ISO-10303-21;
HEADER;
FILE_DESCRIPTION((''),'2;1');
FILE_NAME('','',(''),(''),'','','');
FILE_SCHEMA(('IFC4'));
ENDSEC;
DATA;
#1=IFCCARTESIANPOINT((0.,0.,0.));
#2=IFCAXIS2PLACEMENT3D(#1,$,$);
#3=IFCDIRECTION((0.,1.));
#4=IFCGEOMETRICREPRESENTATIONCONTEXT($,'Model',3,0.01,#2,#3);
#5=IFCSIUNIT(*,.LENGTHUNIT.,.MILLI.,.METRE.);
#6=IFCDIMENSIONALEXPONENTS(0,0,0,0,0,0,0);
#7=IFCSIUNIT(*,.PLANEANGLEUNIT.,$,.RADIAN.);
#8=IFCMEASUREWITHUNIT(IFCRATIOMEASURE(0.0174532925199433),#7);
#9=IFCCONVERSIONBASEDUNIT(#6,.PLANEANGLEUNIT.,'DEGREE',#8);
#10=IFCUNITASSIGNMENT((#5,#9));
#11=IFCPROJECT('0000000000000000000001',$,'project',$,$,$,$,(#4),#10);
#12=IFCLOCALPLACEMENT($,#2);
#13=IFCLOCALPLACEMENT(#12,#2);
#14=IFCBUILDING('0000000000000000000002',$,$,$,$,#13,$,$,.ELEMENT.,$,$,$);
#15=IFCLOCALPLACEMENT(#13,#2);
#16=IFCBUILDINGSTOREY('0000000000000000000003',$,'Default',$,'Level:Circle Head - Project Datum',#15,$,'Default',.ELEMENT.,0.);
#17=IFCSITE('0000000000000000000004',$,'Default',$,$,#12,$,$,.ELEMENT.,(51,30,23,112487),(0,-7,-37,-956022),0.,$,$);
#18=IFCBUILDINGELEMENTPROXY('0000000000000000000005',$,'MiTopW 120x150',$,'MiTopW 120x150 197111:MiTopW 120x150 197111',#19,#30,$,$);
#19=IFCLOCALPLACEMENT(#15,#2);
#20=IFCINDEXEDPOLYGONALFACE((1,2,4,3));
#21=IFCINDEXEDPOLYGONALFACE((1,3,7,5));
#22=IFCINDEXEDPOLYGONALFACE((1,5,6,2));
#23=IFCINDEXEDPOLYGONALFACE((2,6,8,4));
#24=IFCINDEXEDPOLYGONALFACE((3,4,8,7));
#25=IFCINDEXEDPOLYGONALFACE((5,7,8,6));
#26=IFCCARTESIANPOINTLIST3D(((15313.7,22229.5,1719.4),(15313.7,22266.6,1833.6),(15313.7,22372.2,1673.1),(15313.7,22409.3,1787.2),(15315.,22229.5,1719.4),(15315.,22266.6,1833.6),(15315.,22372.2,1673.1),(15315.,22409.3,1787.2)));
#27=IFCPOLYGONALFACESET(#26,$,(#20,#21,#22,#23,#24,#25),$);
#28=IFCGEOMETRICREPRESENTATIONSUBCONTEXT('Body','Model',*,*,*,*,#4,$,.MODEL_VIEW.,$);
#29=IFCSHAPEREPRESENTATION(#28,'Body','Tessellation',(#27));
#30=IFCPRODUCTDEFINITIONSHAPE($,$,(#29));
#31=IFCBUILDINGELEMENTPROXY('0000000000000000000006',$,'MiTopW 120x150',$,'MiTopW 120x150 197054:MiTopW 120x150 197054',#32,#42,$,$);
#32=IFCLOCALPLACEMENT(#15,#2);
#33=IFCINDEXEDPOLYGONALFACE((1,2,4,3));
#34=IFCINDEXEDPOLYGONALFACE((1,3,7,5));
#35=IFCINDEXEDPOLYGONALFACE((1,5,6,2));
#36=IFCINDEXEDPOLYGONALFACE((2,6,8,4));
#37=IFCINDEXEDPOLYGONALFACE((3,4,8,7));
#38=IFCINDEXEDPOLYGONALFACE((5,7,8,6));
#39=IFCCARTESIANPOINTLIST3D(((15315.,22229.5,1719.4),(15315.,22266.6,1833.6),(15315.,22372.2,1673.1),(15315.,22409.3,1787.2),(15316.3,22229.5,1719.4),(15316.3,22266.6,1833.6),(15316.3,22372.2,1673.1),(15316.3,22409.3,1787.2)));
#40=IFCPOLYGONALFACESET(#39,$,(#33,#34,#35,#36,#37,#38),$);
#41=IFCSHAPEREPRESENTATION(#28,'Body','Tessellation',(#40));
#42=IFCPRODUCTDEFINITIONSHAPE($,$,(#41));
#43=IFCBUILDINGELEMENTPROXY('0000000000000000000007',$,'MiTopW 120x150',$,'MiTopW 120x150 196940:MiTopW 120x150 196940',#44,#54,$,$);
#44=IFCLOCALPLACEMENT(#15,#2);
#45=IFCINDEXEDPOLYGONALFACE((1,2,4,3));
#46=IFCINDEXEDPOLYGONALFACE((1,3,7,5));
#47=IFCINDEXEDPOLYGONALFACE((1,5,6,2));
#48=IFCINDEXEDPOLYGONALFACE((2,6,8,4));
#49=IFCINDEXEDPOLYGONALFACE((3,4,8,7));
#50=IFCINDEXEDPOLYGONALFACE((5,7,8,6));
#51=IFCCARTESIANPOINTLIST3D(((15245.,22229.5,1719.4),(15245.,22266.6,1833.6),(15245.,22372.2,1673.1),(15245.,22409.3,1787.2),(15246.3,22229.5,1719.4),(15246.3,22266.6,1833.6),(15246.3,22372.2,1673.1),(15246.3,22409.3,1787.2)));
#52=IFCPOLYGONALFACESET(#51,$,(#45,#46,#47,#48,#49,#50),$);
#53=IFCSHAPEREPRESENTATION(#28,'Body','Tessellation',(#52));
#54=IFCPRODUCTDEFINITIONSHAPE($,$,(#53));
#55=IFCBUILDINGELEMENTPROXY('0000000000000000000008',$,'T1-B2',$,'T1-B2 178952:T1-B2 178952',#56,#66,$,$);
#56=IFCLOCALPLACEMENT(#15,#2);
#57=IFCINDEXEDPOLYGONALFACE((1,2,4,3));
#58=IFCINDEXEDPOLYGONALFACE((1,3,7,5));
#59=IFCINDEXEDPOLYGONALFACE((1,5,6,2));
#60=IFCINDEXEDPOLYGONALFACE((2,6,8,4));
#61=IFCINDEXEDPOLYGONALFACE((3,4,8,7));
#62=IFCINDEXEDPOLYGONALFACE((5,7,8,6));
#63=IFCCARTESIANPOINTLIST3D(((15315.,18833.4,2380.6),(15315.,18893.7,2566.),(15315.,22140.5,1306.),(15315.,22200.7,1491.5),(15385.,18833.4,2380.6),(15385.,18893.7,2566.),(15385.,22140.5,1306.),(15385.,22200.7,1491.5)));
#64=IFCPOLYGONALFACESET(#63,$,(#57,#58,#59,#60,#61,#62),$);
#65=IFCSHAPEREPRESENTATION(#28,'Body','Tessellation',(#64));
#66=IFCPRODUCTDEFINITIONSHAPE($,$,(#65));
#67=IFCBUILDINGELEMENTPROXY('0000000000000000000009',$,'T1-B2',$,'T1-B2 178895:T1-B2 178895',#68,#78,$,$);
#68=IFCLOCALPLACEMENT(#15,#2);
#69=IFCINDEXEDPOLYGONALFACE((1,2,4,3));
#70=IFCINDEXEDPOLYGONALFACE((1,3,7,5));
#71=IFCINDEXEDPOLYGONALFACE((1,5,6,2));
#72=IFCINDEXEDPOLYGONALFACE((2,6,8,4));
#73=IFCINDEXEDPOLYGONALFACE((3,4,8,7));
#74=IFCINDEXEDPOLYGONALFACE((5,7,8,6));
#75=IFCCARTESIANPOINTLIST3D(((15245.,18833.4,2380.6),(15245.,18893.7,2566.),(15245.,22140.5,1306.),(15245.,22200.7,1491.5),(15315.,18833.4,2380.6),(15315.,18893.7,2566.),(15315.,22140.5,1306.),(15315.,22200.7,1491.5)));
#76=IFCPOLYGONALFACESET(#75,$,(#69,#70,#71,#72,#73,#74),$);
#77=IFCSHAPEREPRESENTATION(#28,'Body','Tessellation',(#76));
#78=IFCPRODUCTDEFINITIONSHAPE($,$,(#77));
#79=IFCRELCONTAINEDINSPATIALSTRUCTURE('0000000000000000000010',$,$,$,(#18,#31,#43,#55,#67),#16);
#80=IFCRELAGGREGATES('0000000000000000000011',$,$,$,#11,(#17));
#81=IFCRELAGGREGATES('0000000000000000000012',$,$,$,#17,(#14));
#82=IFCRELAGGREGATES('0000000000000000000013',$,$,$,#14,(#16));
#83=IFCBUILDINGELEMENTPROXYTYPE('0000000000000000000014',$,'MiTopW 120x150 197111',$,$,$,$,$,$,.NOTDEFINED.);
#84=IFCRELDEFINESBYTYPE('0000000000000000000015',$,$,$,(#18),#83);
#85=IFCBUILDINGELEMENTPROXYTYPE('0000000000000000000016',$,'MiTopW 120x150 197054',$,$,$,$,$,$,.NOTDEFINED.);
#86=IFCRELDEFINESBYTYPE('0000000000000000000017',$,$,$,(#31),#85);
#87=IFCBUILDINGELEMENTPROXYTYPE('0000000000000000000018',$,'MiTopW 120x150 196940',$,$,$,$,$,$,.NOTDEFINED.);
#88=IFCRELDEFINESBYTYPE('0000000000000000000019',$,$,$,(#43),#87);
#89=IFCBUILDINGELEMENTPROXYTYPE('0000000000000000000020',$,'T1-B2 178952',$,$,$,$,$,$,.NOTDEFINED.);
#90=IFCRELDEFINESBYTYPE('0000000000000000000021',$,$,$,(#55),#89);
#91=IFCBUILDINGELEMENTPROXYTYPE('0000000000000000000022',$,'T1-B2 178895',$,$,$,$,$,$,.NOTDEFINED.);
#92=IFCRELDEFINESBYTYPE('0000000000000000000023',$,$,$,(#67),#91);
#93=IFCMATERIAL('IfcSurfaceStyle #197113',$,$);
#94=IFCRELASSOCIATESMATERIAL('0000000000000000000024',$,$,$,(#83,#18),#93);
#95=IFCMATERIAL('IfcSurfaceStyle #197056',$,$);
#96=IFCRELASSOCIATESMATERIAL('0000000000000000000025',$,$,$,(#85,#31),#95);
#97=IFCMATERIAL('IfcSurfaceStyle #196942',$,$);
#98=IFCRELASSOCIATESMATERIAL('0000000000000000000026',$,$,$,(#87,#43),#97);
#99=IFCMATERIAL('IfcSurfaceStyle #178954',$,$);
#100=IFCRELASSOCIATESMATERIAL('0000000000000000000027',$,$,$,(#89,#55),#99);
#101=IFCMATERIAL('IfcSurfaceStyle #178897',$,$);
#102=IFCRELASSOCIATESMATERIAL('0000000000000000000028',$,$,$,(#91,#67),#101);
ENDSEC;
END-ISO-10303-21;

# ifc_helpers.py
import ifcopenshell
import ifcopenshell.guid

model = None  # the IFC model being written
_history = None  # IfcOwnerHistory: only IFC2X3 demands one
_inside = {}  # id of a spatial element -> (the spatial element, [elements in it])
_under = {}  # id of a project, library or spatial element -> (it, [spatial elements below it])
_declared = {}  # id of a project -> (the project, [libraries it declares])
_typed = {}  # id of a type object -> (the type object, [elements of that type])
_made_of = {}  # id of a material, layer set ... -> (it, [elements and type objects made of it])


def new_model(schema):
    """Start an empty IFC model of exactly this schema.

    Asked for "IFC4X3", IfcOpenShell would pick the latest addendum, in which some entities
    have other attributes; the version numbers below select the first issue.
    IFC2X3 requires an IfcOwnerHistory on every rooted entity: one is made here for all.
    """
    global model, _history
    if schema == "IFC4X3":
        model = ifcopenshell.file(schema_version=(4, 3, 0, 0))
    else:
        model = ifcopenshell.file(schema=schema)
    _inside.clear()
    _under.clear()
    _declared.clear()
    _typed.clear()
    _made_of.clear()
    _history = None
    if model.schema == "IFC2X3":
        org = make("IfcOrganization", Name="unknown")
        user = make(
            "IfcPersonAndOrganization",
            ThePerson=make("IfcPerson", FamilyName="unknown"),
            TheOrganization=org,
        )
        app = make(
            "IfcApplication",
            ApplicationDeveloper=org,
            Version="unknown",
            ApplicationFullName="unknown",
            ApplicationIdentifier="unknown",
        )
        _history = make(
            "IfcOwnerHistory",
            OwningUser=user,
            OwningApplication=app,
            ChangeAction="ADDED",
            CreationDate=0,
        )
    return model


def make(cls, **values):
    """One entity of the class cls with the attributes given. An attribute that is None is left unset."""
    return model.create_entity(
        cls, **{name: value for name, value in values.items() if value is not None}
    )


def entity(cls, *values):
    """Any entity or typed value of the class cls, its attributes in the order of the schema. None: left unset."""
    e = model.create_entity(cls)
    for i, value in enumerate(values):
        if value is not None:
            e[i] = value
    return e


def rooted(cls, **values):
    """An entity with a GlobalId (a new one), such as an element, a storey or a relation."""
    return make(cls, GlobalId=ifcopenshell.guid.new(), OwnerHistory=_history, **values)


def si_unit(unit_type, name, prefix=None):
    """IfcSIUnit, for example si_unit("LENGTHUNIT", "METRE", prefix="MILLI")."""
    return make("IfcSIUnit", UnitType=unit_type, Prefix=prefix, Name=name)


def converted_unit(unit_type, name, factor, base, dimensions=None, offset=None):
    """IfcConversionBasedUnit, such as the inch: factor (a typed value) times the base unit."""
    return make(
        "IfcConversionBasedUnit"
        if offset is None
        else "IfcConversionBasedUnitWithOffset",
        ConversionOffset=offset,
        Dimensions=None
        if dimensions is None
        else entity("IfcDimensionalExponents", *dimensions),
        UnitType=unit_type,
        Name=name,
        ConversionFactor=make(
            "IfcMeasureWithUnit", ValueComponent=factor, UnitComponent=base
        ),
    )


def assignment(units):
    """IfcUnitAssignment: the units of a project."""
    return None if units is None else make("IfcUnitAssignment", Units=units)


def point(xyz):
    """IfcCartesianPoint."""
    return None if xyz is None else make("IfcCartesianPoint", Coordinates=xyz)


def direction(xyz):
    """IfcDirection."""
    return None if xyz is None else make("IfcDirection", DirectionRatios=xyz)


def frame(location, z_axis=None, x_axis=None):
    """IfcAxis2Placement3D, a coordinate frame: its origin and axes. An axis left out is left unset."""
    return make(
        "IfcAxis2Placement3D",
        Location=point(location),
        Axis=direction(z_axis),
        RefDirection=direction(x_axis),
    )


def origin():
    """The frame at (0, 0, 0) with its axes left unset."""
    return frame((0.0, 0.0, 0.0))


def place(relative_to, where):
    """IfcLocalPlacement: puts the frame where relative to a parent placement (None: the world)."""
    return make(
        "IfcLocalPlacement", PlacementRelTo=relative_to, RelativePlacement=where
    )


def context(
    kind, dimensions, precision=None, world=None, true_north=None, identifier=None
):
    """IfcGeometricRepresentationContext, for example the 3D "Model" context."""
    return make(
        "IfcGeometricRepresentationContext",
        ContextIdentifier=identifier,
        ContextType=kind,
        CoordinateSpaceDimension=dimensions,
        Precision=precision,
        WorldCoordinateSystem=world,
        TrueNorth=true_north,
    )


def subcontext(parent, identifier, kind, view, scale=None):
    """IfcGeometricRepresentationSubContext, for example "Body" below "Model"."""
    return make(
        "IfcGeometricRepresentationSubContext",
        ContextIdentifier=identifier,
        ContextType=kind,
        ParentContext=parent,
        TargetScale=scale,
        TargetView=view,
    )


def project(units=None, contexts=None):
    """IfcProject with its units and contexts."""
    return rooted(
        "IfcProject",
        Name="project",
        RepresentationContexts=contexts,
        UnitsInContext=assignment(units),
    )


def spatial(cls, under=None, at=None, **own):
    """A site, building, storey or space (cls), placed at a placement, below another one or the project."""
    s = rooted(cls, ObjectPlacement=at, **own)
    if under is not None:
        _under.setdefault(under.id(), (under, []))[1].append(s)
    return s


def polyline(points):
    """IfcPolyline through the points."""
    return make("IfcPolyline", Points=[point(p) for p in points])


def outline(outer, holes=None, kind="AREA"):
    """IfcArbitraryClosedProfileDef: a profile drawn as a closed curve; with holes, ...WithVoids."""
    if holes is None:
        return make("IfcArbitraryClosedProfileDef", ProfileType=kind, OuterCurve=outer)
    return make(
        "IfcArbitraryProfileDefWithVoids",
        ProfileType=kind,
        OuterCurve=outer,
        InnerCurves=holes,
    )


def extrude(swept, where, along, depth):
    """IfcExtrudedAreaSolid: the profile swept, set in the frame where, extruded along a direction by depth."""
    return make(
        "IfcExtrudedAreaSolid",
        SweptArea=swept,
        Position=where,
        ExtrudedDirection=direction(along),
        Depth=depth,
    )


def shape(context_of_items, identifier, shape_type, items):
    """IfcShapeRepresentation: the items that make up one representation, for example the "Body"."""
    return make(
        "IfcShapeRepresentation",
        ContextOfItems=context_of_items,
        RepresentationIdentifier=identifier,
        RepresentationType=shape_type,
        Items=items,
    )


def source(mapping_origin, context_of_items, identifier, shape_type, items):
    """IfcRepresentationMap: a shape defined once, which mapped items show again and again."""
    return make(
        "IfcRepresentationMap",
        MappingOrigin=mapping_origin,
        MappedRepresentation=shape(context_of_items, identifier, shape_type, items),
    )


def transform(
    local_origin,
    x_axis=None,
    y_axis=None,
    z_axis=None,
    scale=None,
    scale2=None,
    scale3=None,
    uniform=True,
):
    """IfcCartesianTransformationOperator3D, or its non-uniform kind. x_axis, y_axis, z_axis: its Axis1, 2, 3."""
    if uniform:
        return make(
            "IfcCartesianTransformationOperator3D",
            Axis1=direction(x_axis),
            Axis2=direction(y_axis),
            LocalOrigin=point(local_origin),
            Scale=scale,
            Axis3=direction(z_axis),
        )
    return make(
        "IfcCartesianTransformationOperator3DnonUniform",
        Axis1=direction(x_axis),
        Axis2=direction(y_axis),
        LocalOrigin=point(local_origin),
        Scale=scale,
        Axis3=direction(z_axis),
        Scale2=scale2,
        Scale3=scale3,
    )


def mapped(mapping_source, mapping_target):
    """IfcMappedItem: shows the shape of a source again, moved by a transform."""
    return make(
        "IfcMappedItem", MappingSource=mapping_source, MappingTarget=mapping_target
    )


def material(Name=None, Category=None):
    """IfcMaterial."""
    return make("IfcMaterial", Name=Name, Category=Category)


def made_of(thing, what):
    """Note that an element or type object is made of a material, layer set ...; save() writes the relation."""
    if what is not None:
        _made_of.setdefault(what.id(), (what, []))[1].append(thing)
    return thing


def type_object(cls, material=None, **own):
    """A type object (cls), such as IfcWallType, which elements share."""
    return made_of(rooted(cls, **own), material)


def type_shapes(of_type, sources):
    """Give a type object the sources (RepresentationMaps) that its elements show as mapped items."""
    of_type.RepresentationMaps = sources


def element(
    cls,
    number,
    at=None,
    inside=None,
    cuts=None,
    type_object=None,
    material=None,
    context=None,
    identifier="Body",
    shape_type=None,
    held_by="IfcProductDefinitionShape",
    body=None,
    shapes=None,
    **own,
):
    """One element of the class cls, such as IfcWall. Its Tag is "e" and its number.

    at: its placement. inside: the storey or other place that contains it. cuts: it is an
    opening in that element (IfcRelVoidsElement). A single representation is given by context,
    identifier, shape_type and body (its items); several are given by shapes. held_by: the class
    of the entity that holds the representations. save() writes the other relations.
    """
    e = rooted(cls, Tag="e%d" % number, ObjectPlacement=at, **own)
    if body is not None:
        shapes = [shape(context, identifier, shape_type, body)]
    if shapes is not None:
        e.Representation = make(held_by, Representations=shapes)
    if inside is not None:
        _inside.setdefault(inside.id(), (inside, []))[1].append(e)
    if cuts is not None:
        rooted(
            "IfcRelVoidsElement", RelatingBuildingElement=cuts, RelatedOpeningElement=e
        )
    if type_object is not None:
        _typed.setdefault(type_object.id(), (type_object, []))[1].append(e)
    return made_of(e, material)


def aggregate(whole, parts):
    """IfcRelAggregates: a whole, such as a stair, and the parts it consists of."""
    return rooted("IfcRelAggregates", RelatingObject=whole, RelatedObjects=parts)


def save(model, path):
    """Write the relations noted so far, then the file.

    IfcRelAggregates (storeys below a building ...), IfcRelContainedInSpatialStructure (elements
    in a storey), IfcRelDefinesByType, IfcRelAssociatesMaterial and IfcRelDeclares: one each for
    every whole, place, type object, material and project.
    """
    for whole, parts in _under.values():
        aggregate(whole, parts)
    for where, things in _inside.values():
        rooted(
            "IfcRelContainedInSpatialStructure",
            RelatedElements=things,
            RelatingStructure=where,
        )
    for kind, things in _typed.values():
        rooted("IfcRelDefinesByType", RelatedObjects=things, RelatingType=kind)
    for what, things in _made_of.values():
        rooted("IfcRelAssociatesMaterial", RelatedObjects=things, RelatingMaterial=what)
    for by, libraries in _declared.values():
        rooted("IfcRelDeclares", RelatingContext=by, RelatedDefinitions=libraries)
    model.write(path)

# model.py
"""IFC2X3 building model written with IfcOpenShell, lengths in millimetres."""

from ifc_helpers import new_model, entity, si_unit, converted_unit, direction, frame, origin, place, context, subcontext, project, spatial, polyline, outline, extrude, source, transform, mapped, material, type_object, type_shapes, element, save


model = new_model("IFC2X3")

# Units and contexts
model_context = context("Model", 3, precision=0.01, world=origin(), true_north=direction((0.0, 1.0)))
body_context = subcontext(model_context, "Body", "Model", "MODEL_VIEW")
ifc_project = project(units=[si_unit("LENGTHUNIT", "METRE", prefix="MILLI"), converted_unit("PLANEANGLEUNIT", "DEGREE", entity("IfcRatioMeasure", 0.0174532925199433), si_unit("PLANEANGLEUNIT", "RADIAN"), dimensions=[0, 0, 0, 0, 0, 0, 0])], contexts=[model_context])

# Site, building, storey
site_placement = place(None, origin())
site = spatial("IfcSite", under=ifc_project, at=site_placement, Name="Default", CompositionType="ELEMENT", RefLatitude=(51, 30, 23, 112487), RefLongitude=(0, -7, -37, -956022), RefElevation=0.0)
building_placement = place(site_placement, origin())
building = spatial("IfcBuilding", under=site, at=building_placement, CompositionType="ELEMENT")
storey_placement = place(building_placement, origin())
storey = spatial("IfcBuildingStorey", under=building, at=storey_placement, Name="Default", ObjectType="Level:Circle Head - Project Datum", LongName="Default", CompositionType="ELEMENT", Elevation=0.0)

# Building element proxies
ifc_material_1 = material(Name="IfcSurfaceStyle #197113")
building_element_proxy_type_1 = type_object("IfcBuildingElementProxyType", Name="MiTopW 120x150 197111", PredefinedType="NOTDEFINED", material=ifc_material_1)
shared_shape_1 = source(origin(), body_context, "Body", "SweptSolid", [
    extrude(outline(polyline([(-75.0, -60.0), (75.0, -60.0), (75.0, 60.0), (-75.0, 60.0), (-75.0, -60.0)])), frame((75.0, 60.0, 0.0), z_axis=(0.0, 0.0, 1.0), x_axis=(-1.0, 0.0, 0.0)), (0.0, 0.0, 1.0), 1.3),
])
type_shapes(building_element_proxy_type_1, [shared_shape_1])
proxy_1_placement = place(building_placement, frame((15315.0, 22372.2, 1673.1), z_axis=(-1.0, 0.0, 0.0), x_axis=(0.0, -0.951057, 0.309017)))
element("IfcBuildingElementProxy", 1, at=proxy_1_placement, inside=storey, type_object=building_element_proxy_type_1, material=ifc_material_1, Name="MiTopW 120x150", ObjectType="MiTopW 120x150 197111:MiTopW 120x150 197111", context=body_context, shape_type="MappedRepresentation", body=[
    mapped(shared_shape_1, transform((0.0, 0.0, 0.0), scale=1.0)),
])
ifc_material_2 = material(Name="IfcSurfaceStyle #197056")
building_element_proxy_type_2 = type_object("IfcBuildingElementProxyType", Name="MiTopW 120x150 197054", PredefinedType="NOTDEFINED", material=ifc_material_2)
shared_shape_2 = source(origin(), body_context, "Body", "SweptSolid", [
    extrude(outline(polyline([(-75.0, -60.0), (75.0, -60.0), (75.0, 60.0), (-75.0, 60.0), (-75.0, -60.0)])), frame((75.0, 60.0, 0.0), z_axis=(0.0, 0.0, 1.0), x_axis=(-1.0, 0.0, 0.0)), (0.0, 0.0, 1.0), 1.3),
])
type_shapes(building_element_proxy_type_2, [shared_shape_2])
proxy_2_placement = place(building_placement, frame((15316.3, 22372.2, 1673.1), z_axis=(-1.0, 0.0, 0.0), x_axis=(0.0, -0.951057, 0.309017)))
element("IfcBuildingElementProxy", 2, at=proxy_2_placement, inside=storey, type_object=building_element_proxy_type_2, material=ifc_material_2, Name="MiTopW 120x150", ObjectType="MiTopW 120x150 197054:MiTopW 120x150 197054", context=body_context, shape_type="MappedRepresentation", body=[
    mapped(shared_shape_2, transform((0.0, 0.0, 0.0), scale=1.0)),
])
ifc_material_3 = material(Name="IfcSurfaceStyle #196942")
building_element_proxy_type_3 = type_object("IfcBuildingElementProxyType", Name="MiTopW 120x150 196940", PredefinedType="NOTDEFINED", material=ifc_material_3)
shared_shape_3 = source(origin(), body_context, "Body", "SweptSolid", [
    extrude(outline(polyline([(-75.0, -60.0), (75.0, -60.0), (75.0, 60.0), (-75.0, 60.0), (-75.0, -60.0)])), frame((75.0, 60.0, 0.0), z_axis=(0.0, 0.0, 1.0), x_axis=(-1.0, 0.0, 0.0)), (0.0, 0.0, 1.0), 1.3),
])
type_shapes(building_element_proxy_type_3, [shared_shape_3])
proxy_3_placement = place(building_placement, frame((15246.3, 22372.2, 1673.1), z_axis=(-1.0, 0.0, 0.0), x_axis=(0.0, -0.951057, 0.309017)))
element("IfcBuildingElementProxy", 3, at=proxy_3_placement, inside=storey, type_object=building_element_proxy_type_3, material=ifc_material_3, Name="MiTopW 120x150", ObjectType="MiTopW 120x150 196940:MiTopW 120x150 196940", context=body_context, shape_type="MappedRepresentation", body=[
    mapped(shared_shape_3, transform((0.0, 0.0, 0.0), scale=1.0)),
])
ifc_material_4 = material(Name="IfcSurfaceStyle #178954")
building_element_proxy_type_4 = type_object("IfcBuildingElementProxyType", Name="T1-B2 178952", PredefinedType="NOTDEFINED", material=ifc_material_4)
shared_shape_4 = source(origin(), body_context, "Body", "SweptSolid", [
    extrude(outline(polyline([(-1738.6, -97.5), (1738.6, -97.5), (1738.6, 97.5), (-1738.6, 97.5), (-1738.6, -97.5)])), frame((1738.6, 97.5, 0.0), z_axis=(0.0, 0.0, 1.0), x_axis=(-1.0, 0.0, 0.0)), (0.0, 0.0, 1.0), 70.0),
])
type_shapes(building_element_proxy_type_4, [shared_shape_4])
proxy_4_placement = place(building_placement, frame((15385.0, 22140.5, 1306.0), z_axis=(-1.0, 0.0, 0.0), x_axis=(0.0, -0.951057, 0.309017)))
element("IfcBuildingElementProxy", 4, at=proxy_4_placement, inside=storey, type_object=building_element_proxy_type_4, material=ifc_material_4, Name="T1-B2", ObjectType="T1-B2 178952:T1-B2 178952", context=body_context, shape_type="MappedRepresentation", body=[
    mapped(shared_shape_4, transform((0.0, 0.0, 0.0), scale=1.0)),
])
ifc_material_5 = material(Name="IfcSurfaceStyle #178897")
building_element_proxy_type_5 = type_object("IfcBuildingElementProxyType", Name="T1-B2 178895", PredefinedType="NOTDEFINED", material=ifc_material_5)
shared_shape_5 = source(origin(), body_context, "Body", "SweptSolid", [
    extrude(outline(polyline([(-1738.6, -97.5), (1738.6, -97.5), (1738.6, 97.5), (-1738.6, 97.5), (-1738.6, -97.5)])), frame((1738.6, 97.5, 0.0), z_axis=(0.0, 0.0, 1.0), x_axis=(-1.0, 0.0, 0.0)), (0.0, 0.0, 1.0), 70.0),
])
type_shapes(building_element_proxy_type_5, [shared_shape_5])
proxy_5_placement = place(building_placement, frame((15315.0, 22140.5, 1306.0), z_axis=(-1.0, 0.0, 0.0), x_axis=(0.0, -0.951057, 0.309017)))
element("IfcBuildingElementProxy", 5, at=proxy_5_placement, inside=storey, type_object=building_element_proxy_type_5, material=ifc_material_5, Name="T1-B2", ObjectType="T1-B2 178895:T1-B2 178895", context=body_context, shape_type="MappedRepresentation", body=[
    mapped(shared_shape_5, transform((0.0, 0.0, 0.0), scale=1.0)),
])

save(model, "model.ifc")
